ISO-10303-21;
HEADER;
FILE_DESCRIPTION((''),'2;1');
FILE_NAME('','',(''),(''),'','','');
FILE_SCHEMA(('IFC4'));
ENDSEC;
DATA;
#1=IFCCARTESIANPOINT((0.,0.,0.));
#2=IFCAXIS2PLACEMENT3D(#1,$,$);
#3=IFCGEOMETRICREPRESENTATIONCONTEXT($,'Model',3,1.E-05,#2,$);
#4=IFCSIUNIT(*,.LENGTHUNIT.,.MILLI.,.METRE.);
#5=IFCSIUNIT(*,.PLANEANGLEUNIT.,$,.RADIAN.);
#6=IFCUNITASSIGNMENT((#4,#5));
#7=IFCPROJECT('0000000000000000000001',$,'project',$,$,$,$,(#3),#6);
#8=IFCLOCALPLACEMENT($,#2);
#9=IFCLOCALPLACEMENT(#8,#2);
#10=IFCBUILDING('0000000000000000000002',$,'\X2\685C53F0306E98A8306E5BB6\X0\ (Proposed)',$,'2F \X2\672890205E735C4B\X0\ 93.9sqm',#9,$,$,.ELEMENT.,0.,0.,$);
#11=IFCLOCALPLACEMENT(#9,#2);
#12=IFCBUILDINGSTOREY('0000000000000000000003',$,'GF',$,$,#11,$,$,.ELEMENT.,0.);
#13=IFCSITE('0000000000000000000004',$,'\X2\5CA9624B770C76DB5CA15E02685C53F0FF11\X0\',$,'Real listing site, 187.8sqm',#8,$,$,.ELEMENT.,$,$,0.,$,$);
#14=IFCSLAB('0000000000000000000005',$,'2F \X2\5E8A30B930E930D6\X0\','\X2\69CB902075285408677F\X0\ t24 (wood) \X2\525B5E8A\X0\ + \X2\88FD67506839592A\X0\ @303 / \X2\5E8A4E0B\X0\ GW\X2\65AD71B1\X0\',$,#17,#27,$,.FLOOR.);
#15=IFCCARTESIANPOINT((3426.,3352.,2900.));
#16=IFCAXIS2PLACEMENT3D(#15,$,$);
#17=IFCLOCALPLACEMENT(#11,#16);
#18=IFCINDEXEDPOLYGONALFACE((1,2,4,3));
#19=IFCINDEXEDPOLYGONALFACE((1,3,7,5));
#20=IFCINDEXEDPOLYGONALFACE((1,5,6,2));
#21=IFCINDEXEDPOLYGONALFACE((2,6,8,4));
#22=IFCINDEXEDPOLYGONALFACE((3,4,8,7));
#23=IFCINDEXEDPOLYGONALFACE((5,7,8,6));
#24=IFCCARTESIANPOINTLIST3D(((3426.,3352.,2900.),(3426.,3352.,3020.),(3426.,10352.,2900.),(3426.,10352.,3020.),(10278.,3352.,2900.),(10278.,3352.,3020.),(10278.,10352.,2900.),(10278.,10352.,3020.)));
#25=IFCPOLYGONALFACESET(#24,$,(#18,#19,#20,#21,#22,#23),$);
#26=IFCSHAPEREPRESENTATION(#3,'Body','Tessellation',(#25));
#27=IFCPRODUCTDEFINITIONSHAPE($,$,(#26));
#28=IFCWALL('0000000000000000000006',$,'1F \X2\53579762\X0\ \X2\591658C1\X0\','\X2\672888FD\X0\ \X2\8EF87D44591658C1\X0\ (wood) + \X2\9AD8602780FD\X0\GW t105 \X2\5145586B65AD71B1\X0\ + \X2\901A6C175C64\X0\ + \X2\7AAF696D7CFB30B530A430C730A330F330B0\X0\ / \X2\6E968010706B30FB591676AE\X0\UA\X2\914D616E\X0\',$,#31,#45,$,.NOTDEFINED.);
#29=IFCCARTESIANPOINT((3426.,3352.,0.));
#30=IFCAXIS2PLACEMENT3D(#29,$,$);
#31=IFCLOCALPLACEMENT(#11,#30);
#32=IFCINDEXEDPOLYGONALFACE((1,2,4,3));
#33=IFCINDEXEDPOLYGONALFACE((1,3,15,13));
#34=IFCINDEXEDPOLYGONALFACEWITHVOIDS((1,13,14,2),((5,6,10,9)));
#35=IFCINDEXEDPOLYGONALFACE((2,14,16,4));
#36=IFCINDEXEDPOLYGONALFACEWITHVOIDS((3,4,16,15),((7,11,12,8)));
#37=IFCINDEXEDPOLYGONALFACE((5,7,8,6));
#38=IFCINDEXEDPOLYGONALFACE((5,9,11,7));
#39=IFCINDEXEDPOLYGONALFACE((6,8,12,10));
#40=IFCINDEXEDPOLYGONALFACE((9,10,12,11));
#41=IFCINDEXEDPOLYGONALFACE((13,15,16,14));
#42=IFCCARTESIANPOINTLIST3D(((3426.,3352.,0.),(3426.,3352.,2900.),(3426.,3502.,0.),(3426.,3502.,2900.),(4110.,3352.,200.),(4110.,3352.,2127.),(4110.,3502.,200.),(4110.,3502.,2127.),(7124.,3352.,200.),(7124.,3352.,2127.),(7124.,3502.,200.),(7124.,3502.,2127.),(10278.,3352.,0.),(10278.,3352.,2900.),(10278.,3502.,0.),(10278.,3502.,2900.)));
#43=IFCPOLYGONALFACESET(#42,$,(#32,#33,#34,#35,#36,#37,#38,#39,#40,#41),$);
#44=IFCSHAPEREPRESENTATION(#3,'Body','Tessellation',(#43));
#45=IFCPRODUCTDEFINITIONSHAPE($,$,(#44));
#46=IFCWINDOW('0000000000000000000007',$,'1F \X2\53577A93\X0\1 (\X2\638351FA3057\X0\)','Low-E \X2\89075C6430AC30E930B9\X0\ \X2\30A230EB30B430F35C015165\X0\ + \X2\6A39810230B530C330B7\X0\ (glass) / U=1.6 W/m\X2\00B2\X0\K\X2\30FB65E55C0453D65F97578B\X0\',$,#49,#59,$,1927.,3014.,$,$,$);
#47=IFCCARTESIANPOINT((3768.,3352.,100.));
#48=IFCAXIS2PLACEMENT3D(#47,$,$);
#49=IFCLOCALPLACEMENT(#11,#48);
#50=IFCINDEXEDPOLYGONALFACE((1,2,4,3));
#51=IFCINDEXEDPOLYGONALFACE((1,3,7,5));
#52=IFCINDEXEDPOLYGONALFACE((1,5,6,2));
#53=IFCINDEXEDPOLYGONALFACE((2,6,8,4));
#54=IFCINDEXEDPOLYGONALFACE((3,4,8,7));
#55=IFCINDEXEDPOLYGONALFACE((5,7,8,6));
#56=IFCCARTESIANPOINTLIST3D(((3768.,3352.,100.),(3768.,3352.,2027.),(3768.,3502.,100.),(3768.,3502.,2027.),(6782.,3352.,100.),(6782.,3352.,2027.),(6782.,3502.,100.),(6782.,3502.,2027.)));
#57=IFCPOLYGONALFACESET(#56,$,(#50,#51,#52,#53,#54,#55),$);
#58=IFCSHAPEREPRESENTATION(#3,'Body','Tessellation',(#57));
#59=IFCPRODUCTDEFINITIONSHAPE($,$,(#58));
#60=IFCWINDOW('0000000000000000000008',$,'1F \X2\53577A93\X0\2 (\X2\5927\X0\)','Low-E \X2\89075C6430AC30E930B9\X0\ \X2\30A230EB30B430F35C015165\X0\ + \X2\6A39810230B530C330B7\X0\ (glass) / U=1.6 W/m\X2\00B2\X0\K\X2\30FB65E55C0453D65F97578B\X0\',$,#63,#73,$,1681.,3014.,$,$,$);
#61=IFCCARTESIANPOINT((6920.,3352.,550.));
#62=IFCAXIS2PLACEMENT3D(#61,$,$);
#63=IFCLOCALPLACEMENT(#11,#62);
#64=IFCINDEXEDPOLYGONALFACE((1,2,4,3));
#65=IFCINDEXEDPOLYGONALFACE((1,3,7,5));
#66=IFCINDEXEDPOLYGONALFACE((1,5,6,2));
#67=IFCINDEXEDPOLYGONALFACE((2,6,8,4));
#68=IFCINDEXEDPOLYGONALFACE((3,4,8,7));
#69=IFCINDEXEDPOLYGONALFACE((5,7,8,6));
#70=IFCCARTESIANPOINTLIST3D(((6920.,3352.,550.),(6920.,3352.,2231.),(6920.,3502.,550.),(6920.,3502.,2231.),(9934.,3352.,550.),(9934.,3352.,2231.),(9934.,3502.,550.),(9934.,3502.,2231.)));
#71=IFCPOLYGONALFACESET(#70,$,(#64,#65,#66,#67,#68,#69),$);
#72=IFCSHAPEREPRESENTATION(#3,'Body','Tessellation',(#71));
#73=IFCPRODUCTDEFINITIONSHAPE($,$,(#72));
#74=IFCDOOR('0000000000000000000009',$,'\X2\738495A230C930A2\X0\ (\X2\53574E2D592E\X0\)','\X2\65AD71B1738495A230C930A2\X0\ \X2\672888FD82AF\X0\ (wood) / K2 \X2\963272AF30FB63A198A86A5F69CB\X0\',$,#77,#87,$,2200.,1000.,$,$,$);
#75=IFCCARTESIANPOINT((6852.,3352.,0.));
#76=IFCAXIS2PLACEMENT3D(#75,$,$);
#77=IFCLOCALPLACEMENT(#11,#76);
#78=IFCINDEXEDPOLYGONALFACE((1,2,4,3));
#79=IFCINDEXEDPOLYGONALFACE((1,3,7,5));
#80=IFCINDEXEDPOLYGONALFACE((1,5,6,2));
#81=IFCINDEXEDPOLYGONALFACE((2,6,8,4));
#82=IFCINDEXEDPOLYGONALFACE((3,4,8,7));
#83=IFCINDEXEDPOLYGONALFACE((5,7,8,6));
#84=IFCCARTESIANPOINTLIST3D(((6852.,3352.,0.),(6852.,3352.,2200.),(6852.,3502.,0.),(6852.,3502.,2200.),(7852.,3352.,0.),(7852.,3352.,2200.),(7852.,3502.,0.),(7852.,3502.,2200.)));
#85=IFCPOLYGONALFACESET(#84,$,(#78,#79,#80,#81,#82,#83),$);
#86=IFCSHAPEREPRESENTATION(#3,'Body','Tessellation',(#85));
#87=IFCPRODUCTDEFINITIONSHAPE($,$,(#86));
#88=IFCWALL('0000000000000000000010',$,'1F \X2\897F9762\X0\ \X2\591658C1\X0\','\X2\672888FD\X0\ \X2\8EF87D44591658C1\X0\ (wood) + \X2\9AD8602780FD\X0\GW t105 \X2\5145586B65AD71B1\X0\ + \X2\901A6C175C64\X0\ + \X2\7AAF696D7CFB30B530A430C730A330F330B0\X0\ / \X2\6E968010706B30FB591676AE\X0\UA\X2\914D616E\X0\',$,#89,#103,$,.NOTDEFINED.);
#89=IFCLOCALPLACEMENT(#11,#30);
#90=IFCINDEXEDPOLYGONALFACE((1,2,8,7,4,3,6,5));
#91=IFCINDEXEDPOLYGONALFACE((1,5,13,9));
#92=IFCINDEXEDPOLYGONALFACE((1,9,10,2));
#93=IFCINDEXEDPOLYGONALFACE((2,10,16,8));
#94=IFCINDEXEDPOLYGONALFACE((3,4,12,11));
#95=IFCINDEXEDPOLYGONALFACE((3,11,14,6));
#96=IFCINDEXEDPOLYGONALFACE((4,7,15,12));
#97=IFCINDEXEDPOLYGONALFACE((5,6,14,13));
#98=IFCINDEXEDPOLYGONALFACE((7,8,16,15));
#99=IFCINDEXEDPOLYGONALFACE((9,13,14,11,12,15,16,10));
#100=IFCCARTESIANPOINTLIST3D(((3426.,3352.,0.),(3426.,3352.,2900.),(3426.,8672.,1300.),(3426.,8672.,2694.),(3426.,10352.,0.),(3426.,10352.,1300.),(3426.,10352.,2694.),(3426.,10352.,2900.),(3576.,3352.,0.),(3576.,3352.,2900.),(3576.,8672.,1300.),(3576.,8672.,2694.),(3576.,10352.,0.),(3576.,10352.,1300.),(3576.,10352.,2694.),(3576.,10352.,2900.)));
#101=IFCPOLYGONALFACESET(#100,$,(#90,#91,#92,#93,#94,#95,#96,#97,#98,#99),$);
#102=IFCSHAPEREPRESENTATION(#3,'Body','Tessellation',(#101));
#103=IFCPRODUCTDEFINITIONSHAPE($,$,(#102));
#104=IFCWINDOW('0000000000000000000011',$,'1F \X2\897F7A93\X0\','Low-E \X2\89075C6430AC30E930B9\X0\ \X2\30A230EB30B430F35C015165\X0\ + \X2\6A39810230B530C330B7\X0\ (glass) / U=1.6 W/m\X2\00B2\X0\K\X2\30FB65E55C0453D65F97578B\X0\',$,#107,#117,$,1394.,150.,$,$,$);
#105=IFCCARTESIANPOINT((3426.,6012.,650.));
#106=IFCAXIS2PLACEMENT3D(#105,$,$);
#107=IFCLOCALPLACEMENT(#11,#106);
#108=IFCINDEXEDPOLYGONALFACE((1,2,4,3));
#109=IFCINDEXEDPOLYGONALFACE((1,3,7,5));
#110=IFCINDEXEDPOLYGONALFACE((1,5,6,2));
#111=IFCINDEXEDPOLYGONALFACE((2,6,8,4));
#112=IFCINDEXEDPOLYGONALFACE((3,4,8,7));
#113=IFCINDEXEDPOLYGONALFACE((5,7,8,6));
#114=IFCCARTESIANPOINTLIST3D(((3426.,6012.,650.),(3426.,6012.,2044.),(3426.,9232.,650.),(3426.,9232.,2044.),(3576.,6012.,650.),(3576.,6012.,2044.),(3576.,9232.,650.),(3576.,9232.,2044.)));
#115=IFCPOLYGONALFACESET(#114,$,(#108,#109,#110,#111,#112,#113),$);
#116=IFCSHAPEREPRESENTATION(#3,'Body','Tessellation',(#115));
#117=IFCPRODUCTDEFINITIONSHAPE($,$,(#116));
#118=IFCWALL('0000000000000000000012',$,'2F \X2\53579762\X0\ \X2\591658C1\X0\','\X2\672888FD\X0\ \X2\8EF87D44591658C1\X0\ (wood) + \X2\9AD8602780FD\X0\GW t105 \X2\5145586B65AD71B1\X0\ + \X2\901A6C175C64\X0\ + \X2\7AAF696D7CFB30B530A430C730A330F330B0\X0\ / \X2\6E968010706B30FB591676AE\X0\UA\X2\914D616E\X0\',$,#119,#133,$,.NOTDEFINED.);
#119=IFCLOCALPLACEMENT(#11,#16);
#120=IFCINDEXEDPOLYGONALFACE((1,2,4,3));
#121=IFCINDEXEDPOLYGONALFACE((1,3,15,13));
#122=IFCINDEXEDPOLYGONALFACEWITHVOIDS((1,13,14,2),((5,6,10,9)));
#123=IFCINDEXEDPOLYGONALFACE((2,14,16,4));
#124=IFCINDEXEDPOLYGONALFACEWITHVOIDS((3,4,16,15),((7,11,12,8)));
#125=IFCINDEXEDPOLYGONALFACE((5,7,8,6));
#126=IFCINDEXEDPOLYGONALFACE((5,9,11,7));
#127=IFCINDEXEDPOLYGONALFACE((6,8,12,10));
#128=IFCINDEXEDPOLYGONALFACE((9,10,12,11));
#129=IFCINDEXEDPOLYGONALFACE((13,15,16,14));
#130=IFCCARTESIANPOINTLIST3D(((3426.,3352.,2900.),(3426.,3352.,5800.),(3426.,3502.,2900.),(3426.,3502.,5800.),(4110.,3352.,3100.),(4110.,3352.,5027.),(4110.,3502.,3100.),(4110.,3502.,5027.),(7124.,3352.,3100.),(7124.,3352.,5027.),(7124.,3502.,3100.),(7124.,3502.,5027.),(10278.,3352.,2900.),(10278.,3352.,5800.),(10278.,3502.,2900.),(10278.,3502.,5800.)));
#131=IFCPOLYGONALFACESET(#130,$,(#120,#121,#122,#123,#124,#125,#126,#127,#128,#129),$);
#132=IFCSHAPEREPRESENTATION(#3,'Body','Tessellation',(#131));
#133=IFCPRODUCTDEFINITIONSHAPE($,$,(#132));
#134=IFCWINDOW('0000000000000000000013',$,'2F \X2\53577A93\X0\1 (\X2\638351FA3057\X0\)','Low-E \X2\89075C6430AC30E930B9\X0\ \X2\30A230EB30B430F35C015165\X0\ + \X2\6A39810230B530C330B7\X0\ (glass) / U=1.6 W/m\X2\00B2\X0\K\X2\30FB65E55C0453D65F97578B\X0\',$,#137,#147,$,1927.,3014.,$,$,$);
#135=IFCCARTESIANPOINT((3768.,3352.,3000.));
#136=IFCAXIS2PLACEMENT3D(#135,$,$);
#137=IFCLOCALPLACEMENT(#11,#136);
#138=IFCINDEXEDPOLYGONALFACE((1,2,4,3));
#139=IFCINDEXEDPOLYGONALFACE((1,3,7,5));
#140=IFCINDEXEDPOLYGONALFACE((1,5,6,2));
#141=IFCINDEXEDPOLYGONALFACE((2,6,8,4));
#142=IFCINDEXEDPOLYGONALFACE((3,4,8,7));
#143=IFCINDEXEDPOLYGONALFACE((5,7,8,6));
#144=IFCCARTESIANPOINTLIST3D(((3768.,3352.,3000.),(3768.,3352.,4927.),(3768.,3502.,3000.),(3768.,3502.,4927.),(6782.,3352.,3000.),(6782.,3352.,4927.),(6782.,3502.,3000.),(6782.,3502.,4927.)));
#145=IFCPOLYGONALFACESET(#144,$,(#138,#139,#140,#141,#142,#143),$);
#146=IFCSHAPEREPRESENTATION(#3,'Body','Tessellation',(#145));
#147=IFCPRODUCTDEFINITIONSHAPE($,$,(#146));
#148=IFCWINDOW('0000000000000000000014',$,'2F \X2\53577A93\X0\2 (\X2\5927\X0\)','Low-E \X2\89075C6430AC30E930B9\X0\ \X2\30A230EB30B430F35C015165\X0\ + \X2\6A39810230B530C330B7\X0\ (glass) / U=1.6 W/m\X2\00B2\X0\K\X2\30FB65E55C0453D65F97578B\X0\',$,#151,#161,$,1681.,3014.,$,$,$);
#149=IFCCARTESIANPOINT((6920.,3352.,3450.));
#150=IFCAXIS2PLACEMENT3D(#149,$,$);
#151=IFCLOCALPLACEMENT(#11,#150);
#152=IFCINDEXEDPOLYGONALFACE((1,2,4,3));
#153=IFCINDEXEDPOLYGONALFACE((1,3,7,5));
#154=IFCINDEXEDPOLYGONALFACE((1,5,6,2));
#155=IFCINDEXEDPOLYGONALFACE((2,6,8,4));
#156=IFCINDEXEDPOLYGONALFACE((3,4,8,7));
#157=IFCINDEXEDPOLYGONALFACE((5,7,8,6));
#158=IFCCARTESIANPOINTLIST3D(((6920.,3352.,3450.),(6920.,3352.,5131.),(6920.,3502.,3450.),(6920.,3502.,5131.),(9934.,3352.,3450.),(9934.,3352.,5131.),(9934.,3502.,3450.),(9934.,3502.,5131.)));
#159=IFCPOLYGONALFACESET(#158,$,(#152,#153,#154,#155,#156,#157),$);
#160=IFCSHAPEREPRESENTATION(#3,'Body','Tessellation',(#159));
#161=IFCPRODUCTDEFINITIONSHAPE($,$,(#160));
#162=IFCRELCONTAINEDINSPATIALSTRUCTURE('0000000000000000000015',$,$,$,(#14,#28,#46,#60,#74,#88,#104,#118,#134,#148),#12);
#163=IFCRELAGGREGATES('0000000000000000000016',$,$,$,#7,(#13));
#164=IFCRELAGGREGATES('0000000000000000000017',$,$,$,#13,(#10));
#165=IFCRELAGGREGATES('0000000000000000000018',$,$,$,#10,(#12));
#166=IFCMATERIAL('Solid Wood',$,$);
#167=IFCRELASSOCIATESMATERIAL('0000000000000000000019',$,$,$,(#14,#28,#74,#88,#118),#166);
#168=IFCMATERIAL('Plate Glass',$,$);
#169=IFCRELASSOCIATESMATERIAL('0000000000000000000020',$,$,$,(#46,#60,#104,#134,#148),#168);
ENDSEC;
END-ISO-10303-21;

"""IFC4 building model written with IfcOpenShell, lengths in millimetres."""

from ifc_helpers import new_model, si_unit, frame, frame_2d, origin, place, context, project, spatial, rectangle, extrude, material, element, fill, save


model = new_model("IFC4")

# Units and contexts
model_context = context("Model", 3, precision=1e-05, world=origin())
ifc_project = project(units=[si_unit("LENGTHUNIT", "METRE", prefix="MILLI"), si_unit("PLANEANGLEUNIT", "RADIAN")], contexts=[model_context])

# Site, building, storey
site_placement = place(None, origin())
site = spatial("IfcSite", under=ifc_project, at=site_placement, Name="岩手県盛岡市桜台１", ObjectType="Real listing site, 187.8sqm", CompositionType="ELEMENT", RefElevation=0.0)
building_placement = place(site_placement, origin())
building = spatial("IfcBuilding", under=site, at=building_placement, Name="桜台の風の家 (Proposed)", ObjectType="2F 木造平屋 93.9sqm", CompositionType="ELEMENT", ElevationOfRefHeight=0.0, ElevationOfTerrain=0.0)
storey_placement = place(building_placement, origin())
storey = spatial("IfcBuildingStorey", under=building, at=storey_placement, Name="GF", CompositionType="ELEMENT", Elevation=0.0)

# Slab
ifc_material_1 = material(Name="Solid Wood")
slab_1_placement = place(storey_placement, frame((3426.0, 3352.0, 2900.0)))
element("IfcSlab", 1, at=slab_1_placement, inside=storey, material=ifc_material_1, Name="2F 床スラブ", Description="構造用合板 t24 (wood) 剛床 + 製材根太 @303 / 床下 GW断熱", PredefinedType="FLOOR", context=model_context, shape_type="SweptSolid", body=[
    extrude(rectangle(XDim=6852.0, YDim=7000.0, at=frame_2d((3426.0, 3500.0))), frame((3426.0, 3352.0, 2900.0)), (0.0, 0.0, 1.0), 120.0),
])

# Wall, openings, windows, door
wall_1_placement = place(storey_placement, frame((3426.0, 3352.0, 0.0)))
wall_1 = element("IfcWall", 2, at=wall_1_placement, inside=storey, material=ifc_material_1, Name="1F 南面 外壁", Description="木製 軸組外壁 (wood) + 高性能GW t105 充填断熱 + 通気層 + 窯業系サイディング / 準耐火・外皮UA配慮", PredefinedType="NOTDEFINED", context=model_context, shape_type="SweptSolid", body=[
    extrude(rectangle(XDim=6852.0, YDim=150.0, at=frame_2d((3426.0, 75.0))), frame((3426.0, 3352.0, 0.0)), (0.0, 0.0, 1.0), 2900.0),
])
opening_1_placement = place(storey_placement, frame((3768.0, 3352.0, 100.0)))
opening_1 = element("IfcOpeningElement", 3, at=opening_1_placement, cuts=wall_1, PredefinedType="NOTDEFINED", context=model_context, shape_type="SweptSolid", body=[
    extrude(rectangle(XDim=3014.0, YDim=150.0, at=frame_2d((1507.0, 75.0))), frame((3768.0, 3352.0, 100.0)), (0.0, 0.0, 1.0), 1927.0),
])
opening_2_placement = place(storey_placement, frame((6920.0, 3352.0, 550.0)))
opening_2 = element("IfcOpeningElement", 4, at=opening_2_placement, cuts=wall_1, PredefinedType="NOTDEFINED", context=model_context, shape_type="SweptSolid", body=[
    extrude(rectangle(XDim=3014.0, YDim=150.0, at=frame_2d((1507.0, 75.0))), frame((6920.0, 3352.0, 550.0)), (0.0, 0.0, 1.0), 1681.0),
])
opening_3_placement = place(storey_placement, frame((6852.0, 3352.0, 0.0)))
opening_3 = element("IfcOpeningElement", 5, at=opening_3_placement, cuts=wall_1, PredefinedType="NOTDEFINED", context=model_context, shape_type="SweptSolid", body=[
    extrude(rectangle(XDim=1000.0, YDim=150.0, at=frame_2d((500.0, 75.0))), frame((6852.0, 3352.0, 0.0)), (0.0, 0.0, 1.0), 2200.0),
])
ifc_material_2 = material(Name="Plate Glass")
window_1_placement = place(storey_placement, frame((3768.0, 3352.0, 100.0)))
window_1 = element("IfcWindow", 6, at=window_1_placement, inside=storey, material=ifc_material_2, Name="1F 南窓1 (掃出し)", Description="Low-E 複層ガラス アルゴン封入 + 樹脂サッシ (glass) / U=1.6 W/m²K・日射取得型", OverallHeight=1927.0, OverallWidth=3014.0, context=model_context, shape_type="SweptSolid", body=[
    extrude(rectangle(XDim=3014.0, YDim=150.0, at=frame_2d((1507.0, 75.0))), frame((3768.0, 3352.0, 100.0)), (0.0, 0.0, 1.0), 1927.0),
])
fill(opening_1, window_1)
window_2_placement = place(storey_placement, frame((6920.0, 3352.0, 550.0)))
window_2 = element("IfcWindow", 7, at=window_2_placement, inside=storey, material=ifc_material_2, Name="1F 南窓2 (大)", Description="Low-E 複層ガラス アルゴン封入 + 樹脂サッシ (glass) / U=1.6 W/m²K・日射取得型", OverallHeight=1681.0, OverallWidth=3014.0, context=model_context, shape_type="SweptSolid", body=[
    extrude(rectangle(XDim=3014.0, YDim=150.0, at=frame_2d((1507.0, 75.0))), frame((6920.0, 3352.0, 550.0)), (0.0, 0.0, 1.0), 1681.0),
])
fill(opening_2, window_2)
door_placement = place(storey_placement, frame((6852.0, 3352.0, 0.0)))
door = element("IfcDoor", 8, at=door_placement, inside=storey, material=ifc_material_1, Name="玄関ドア (南中央)", Description="断熱玄関ドア 木製芯 (wood) / K2 防犯・採風機構", OverallHeight=2200.0, OverallWidth=1000.0, context=model_context, shape_type="SweptSolid", body=[
    extrude(rectangle(XDim=1000.0, YDim=150.0, at=frame_2d((500.0, 75.0))), frame((6852.0, 3352.0, 0.0)), (0.0, 0.0, 1.0), 2200.0),
])
fill(opening_3, door)

# Wall, opening, window
wall_2_placement = place(storey_placement, frame((3426.0, 3352.0, 0.0)))
wall_2 = element("IfcWall", 9, at=wall_2_placement, inside=storey, material=ifc_material_1, Name="1F 西面 外壁", Description="木製 軸組外壁 (wood) + 高性能GW t105 充填断熱 + 通気層 + 窯業系サイディング / 準耐火・外皮UA配慮", PredefinedType="NOTDEFINED", context=model_context, shape_type="SweptSolid", body=[
    extrude(rectangle(XDim=150.0, YDim=7000.0, at=frame_2d((75.0, 3500.0))), frame((3426.0, 3352.0, 0.0)), (0.0, 0.0, 1.0), 2900.0),
])
opening_4_placement = place(storey_placement, frame((3426.0, 6012.0, 650.0)))
opening_4 = element("IfcOpeningElement", 10, at=opening_4_placement, cuts=wall_2, PredefinedType="NOTDEFINED", context=model_context, shape_type="SweptSolid", body=[
    extrude(rectangle(XDim=150.0, YDim=3220.0, at=frame_2d((75.0, 1610.0))), frame((3426.0, 6012.0, 650.0)), (0.0, 0.0, 1.0), 1394.0),
])
window_3_placement = place(storey_placement, frame((3426.0, 6012.0, 650.0)))
window_3 = element("IfcWindow", 11, at=window_3_placement, inside=storey, material=ifc_material_2, Name="1F 西窓", Description="Low-E 複層ガラス アルゴン封入 + 樹脂サッシ (glass) / U=1.6 W/m²K・日射取得型", OverallHeight=1394.0, OverallWidth=150.0, context=model_context, shape_type="SweptSolid", body=[
    extrude(rectangle(XDim=150.0, YDim=3220.0, at=frame_2d((75.0, 1610.0))), frame((3426.0, 6012.0, 650.0)), (0.0, 0.0, 1.0), 1394.0),
])
fill(opening_4, window_3)

# Wall, openings, windows
wall_3_placement = place(storey_placement, frame((3426.0, 3352.0, 2900.0)))
wall_3 = element("IfcWall", 12, at=wall_3_placement, inside=storey, material=ifc_material_1, Name="2F 南面 外壁", Description="木製 軸組外壁 (wood) + 高性能GW t105 充填断熱 + 通気層 + 窯業系サイディング / 準耐火・外皮UA配慮", PredefinedType="NOTDEFINED", context=model_context, shape_type="SweptSolid", body=[
    extrude(rectangle(XDim=6852.0, YDim=150.0, at=frame_2d((3426.0, 75.0))), frame((3426.0, 3352.0, 2900.0)), (0.0, 0.0, 1.0), 2900.0),
])
opening_5_placement = place(storey_placement, frame((3768.0, 3352.0, 3000.0)))
opening_5 = element("IfcOpeningElement", 13, at=opening_5_placement, cuts=wall_3, PredefinedType="NOTDEFINED", context=model_context, shape_type="SweptSolid", body=[
    extrude(rectangle(XDim=3014.0, YDim=150.0, at=frame_2d((1507.0, 75.0))), frame((3768.0, 3352.0, 3000.0)), (0.0, 0.0, 1.0), 1927.0),
])
opening_6_placement = place(storey_placement, frame((6920.0, 3352.0, 3450.0)))
opening_6 = element("IfcOpeningElement", 14, at=opening_6_placement, cuts=wall_3, PredefinedType="NOTDEFINED", context=model_context, shape_type="SweptSolid", body=[
    extrude(rectangle(XDim=3014.0, YDim=150.0, at=frame_2d((1507.0, 75.0))), frame((6920.0, 3352.0, 3450.0)), (0.0, 0.0, 1.0), 1681.0),
])
window_4_placement = place(storey_placement, frame((3768.0, 3352.0, 3000.0)))
window_4 = element("IfcWindow", 15, at=window_4_placement, inside=storey, material=ifc_material_2, Name="2F 南窓1 (掃出し)", Description="Low-E 複層ガラス アルゴン封入 + 樹脂サッシ (glass) / U=1.6 W/m²K・日射取得型", OverallHeight=1927.0, OverallWidth=3014.0, context=model_context, shape_type="SweptSolid", body=[
    extrude(rectangle(XDim=3014.0, YDim=150.0, at=frame_2d((1507.0, 75.0))), frame((3768.0, 3352.0, 3000.0)), (0.0, 0.0, 1.0), 1927.0),
])
fill(opening_5, window_4)
window_5_placement = place(storey_placement, frame((6920.0, 3352.0, 3450.0)))
window_5 = element("IfcWindow", 16, at=window_5_placement, inside=storey, material=ifc_material_2, Name="2F 南窓2 (大)", Description="Low-E 複層ガラス アルゴン封入 + 樹脂サッシ (glass) / U=1.6 W/m²K・日射取得型", OverallHeight=1681.0, OverallWidth=3014.0, context=model_context, shape_type="SweptSolid", body=[
    extrude(rectangle(XDim=3014.0, YDim=150.0, at=frame_2d((1507.0, 75.0))), frame((6920.0, 3352.0, 3450.0)), (0.0, 0.0, 1.0), 1681.0),
])
fill(opening_6, window_5)

save(model, "model.ifc")
